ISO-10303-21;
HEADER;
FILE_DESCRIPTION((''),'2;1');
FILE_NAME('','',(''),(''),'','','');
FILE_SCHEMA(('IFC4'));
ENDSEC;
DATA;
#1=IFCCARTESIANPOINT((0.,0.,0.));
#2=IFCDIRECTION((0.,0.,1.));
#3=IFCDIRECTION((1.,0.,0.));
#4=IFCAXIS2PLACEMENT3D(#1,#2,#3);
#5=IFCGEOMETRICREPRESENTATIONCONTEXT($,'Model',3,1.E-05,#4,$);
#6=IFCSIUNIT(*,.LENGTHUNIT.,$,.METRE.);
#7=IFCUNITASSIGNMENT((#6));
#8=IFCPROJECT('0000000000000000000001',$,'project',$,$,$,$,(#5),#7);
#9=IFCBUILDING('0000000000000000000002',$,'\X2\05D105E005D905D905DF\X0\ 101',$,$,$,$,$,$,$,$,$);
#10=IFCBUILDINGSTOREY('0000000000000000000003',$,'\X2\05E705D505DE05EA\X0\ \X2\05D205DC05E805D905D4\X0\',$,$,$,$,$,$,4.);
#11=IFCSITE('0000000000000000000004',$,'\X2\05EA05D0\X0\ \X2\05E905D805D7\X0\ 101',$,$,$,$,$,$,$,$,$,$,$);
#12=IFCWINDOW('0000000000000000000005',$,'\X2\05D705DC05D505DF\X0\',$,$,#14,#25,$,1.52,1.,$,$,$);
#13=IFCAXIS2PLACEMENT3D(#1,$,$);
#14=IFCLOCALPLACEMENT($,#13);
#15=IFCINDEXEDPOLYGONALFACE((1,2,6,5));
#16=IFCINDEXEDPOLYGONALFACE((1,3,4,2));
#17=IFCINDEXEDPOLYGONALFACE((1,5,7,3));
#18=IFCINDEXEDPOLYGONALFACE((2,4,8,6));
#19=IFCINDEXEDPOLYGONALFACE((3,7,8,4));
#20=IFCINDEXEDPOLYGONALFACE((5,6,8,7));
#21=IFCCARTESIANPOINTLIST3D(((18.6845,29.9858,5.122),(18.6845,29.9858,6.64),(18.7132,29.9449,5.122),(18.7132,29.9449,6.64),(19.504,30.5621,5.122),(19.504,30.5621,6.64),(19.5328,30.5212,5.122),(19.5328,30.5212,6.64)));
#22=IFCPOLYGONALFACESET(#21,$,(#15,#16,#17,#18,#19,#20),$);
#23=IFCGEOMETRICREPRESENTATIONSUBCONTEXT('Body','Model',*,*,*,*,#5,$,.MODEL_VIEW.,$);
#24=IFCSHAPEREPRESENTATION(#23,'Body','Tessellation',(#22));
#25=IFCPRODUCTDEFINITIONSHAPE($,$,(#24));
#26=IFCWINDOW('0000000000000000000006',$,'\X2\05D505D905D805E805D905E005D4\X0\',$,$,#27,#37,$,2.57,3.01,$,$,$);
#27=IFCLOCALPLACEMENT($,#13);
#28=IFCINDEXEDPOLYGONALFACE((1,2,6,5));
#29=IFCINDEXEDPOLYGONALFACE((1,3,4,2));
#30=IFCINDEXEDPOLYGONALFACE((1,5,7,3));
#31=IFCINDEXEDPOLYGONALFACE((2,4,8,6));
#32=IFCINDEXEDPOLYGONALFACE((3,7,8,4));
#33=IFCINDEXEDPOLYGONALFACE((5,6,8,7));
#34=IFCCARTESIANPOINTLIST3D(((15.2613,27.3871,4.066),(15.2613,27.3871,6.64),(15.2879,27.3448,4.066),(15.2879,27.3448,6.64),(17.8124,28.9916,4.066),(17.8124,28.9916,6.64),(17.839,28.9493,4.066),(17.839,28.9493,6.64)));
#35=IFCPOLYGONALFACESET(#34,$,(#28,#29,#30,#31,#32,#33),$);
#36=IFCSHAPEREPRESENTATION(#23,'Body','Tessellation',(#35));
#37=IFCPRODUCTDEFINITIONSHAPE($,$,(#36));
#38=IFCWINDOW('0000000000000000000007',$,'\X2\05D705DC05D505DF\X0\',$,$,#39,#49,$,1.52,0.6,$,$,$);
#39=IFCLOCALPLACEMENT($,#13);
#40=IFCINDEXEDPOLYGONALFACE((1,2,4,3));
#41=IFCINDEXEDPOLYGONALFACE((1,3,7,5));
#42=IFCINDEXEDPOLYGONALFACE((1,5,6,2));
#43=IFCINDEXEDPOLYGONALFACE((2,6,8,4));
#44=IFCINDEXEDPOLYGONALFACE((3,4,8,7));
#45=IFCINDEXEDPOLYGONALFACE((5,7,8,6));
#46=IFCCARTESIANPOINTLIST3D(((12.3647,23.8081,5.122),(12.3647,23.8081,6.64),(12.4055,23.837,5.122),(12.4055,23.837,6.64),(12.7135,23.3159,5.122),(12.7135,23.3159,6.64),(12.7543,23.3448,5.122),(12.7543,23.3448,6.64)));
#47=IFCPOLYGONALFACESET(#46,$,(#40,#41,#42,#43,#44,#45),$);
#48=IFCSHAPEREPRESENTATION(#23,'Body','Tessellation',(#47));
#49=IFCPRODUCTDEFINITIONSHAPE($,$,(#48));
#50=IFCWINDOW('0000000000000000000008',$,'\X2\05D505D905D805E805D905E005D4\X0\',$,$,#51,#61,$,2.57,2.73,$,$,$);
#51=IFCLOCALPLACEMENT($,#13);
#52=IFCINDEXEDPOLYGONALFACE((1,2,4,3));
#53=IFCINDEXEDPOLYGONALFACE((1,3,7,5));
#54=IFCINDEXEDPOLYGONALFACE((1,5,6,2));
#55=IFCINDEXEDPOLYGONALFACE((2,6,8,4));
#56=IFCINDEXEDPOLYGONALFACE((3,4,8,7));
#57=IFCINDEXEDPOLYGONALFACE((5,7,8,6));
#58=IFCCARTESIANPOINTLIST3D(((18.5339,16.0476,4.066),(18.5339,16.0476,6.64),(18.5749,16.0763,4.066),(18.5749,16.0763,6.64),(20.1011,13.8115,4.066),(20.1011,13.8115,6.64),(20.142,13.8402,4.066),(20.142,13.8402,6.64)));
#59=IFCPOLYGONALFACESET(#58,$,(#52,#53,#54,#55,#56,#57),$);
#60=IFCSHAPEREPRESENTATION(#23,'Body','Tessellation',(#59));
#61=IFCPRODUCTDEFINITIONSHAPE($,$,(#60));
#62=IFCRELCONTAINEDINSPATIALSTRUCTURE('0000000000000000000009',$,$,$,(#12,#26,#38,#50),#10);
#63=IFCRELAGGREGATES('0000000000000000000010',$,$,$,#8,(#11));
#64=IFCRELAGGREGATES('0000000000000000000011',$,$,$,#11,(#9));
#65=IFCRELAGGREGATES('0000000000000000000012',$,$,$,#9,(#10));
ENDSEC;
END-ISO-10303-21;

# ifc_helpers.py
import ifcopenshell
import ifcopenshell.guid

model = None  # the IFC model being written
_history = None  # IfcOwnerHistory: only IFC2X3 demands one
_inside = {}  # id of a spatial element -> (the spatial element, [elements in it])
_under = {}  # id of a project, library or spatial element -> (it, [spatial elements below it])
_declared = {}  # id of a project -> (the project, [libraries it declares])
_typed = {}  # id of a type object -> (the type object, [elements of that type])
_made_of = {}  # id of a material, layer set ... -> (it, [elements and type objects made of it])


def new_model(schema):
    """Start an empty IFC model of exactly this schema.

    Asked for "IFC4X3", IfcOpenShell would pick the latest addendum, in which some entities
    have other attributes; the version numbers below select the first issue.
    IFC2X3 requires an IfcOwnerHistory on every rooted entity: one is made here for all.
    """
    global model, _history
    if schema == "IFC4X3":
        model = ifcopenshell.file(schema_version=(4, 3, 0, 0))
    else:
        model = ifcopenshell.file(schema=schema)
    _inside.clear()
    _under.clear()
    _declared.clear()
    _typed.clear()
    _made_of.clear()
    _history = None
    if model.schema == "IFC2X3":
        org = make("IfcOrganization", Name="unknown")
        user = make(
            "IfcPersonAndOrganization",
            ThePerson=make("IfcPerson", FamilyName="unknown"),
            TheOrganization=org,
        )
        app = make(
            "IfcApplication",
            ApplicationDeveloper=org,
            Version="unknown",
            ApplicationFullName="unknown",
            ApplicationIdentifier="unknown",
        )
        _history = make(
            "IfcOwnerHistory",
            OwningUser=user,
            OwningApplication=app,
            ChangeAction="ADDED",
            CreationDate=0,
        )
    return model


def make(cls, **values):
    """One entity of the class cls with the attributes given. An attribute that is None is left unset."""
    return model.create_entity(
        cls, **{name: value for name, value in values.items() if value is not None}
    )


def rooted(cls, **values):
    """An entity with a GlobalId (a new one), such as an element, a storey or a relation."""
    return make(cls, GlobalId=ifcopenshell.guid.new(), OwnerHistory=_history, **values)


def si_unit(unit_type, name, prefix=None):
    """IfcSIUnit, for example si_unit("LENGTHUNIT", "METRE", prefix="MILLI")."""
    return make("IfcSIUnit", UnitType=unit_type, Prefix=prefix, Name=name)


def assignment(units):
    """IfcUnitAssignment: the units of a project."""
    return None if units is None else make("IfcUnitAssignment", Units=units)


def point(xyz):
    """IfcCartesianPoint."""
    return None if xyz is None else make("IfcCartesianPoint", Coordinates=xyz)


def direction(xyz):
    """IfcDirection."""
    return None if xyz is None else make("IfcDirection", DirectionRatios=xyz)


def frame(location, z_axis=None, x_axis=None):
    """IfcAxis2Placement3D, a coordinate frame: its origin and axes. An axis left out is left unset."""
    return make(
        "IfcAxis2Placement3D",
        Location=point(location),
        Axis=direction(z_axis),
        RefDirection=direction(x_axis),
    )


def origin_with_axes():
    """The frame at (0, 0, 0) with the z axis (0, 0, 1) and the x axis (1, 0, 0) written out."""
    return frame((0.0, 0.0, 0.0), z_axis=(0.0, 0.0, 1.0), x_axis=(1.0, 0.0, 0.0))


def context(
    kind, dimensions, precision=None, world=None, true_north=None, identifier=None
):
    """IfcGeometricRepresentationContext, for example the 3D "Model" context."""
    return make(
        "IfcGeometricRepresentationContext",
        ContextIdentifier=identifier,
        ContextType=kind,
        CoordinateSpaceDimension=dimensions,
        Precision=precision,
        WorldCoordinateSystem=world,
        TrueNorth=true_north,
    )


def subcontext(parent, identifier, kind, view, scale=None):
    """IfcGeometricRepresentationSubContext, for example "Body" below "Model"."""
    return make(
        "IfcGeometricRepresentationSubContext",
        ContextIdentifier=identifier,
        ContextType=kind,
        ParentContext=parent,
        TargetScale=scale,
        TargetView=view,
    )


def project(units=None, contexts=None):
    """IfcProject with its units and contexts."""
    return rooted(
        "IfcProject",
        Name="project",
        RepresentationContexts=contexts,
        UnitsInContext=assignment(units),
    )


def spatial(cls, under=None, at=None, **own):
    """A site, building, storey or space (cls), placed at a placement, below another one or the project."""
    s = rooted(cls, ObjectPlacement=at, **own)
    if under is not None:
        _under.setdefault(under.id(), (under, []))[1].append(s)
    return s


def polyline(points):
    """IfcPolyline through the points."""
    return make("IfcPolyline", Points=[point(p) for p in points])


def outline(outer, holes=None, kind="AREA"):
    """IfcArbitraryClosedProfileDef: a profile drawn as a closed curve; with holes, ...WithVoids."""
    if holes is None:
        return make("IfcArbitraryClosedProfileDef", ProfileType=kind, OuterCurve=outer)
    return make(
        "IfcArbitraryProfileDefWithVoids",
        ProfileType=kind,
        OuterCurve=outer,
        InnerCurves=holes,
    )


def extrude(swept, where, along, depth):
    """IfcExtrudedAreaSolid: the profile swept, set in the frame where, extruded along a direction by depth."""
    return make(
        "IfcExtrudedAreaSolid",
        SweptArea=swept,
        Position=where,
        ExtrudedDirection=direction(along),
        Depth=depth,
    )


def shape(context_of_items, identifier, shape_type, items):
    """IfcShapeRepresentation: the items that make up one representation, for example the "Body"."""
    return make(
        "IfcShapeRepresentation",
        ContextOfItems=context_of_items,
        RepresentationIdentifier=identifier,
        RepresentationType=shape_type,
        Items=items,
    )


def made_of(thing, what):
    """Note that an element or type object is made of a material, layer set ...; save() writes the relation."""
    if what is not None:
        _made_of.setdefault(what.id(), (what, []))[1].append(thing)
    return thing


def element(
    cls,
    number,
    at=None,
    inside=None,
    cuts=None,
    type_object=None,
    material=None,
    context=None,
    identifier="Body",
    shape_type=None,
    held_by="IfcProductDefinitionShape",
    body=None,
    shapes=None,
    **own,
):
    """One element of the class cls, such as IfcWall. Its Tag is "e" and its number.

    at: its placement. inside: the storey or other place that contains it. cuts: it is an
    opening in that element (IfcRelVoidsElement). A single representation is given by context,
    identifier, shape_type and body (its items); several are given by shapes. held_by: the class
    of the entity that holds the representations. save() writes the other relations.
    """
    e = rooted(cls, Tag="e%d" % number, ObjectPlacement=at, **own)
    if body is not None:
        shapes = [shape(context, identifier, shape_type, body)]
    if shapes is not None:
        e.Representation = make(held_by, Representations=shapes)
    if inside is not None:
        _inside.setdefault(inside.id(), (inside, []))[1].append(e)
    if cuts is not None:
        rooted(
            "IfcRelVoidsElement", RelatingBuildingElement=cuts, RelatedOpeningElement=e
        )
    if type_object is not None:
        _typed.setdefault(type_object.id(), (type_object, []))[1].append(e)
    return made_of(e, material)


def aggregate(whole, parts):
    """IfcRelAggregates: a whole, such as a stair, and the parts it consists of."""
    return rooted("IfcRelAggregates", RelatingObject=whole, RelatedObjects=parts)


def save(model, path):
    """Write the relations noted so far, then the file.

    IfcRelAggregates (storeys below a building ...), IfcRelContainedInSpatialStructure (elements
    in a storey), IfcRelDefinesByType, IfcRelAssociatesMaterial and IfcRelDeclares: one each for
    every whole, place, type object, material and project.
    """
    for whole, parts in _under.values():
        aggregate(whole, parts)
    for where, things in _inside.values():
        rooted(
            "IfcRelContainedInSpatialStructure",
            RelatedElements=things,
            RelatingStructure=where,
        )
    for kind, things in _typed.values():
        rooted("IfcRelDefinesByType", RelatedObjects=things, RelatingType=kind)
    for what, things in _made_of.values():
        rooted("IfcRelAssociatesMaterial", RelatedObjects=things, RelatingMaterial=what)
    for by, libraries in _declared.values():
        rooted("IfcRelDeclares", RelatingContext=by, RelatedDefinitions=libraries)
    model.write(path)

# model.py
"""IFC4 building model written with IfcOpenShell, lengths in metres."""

from ifc_helpers import new_model, si_unit, frame, origin_with_axes, context, subcontext, project, spatial, polyline, outline, extrude, element, save


model = new_model("IFC4")

# Units and contexts
model_context = context("Model", 3, precision=1e-05, world=origin_with_axes())
body_context = subcontext(model_context, "Body", "Model", "MODEL_VIEW")
ifc_project = project(units=[si_unit("LENGTHUNIT", "METRE")], contexts=[model_context])

# Site, building, storey
site = spatial("IfcSite", under=ifc_project, Name="תא שטח 101")
building = spatial("IfcBuilding", under=site, Name="בניין 101")
storey = spatial("IfcBuildingStorey", under=building, Name="קומת גלריה", Elevation=4.0)

# Windows
element("IfcWindow", 1, inside=storey, Name="חלון", OverallHeight=1.52, OverallWidth=1.0, context=body_context, shape_type="SweptSolid", body=[
    extrude(outline(polyline([(19.504, 30.5621), (18.6845, 29.9858), (18.7132, 29.9449), (19.5328, 30.5212), (19.504, 30.5621)])), frame((0.0, 0.0, 5.122)), (0.0, 0.0, 1.0), 1.518),
])
element("IfcWindow", 2, inside=storey, Name="ויטרינה", OverallHeight=2.57, OverallWidth=3.01, context=body_context, shape_type="SweptSolid", body=[
    extrude(outline(polyline([(17.8124, 28.9916), (15.2613, 27.3871), (15.2879, 27.3448), (17.839, 28.9493), (17.8124, 28.9916)])), frame((0.0, 0.0, 4.066)), (0.0, 0.0, 1.0), 2.574),
])
element("IfcWindow", 3, inside=storey, Name="חלון", OverallHeight=1.52, OverallWidth=0.6, context=body_context, shape_type="SweptSolid", body=[
    extrude(outline(polyline([(12.3647, 23.8081), (12.7135, 23.3159), (12.7543, 23.3448), (12.4055, 23.837), (12.3647, 23.8081)])), frame((0.0, 0.0, 5.122)), (0.0, 0.0, 1.0), 1.518),
])
element("IfcWindow", 4, inside=storey, Name="ויטרינה", OverallHeight=2.57, OverallWidth=2.73, context=body_context, shape_type="SweptSolid", body=[
    extrude(outline(polyline([(18.5339, 16.0476), (20.1011, 13.8115), (20.142, 13.8402), (18.5749, 16.0763), (18.5339, 16.0476)])), frame((0.0, 0.0, 4.066)), (0.0, 0.0, 1.0), 2.574),
])

save(model, "model.ifc")
